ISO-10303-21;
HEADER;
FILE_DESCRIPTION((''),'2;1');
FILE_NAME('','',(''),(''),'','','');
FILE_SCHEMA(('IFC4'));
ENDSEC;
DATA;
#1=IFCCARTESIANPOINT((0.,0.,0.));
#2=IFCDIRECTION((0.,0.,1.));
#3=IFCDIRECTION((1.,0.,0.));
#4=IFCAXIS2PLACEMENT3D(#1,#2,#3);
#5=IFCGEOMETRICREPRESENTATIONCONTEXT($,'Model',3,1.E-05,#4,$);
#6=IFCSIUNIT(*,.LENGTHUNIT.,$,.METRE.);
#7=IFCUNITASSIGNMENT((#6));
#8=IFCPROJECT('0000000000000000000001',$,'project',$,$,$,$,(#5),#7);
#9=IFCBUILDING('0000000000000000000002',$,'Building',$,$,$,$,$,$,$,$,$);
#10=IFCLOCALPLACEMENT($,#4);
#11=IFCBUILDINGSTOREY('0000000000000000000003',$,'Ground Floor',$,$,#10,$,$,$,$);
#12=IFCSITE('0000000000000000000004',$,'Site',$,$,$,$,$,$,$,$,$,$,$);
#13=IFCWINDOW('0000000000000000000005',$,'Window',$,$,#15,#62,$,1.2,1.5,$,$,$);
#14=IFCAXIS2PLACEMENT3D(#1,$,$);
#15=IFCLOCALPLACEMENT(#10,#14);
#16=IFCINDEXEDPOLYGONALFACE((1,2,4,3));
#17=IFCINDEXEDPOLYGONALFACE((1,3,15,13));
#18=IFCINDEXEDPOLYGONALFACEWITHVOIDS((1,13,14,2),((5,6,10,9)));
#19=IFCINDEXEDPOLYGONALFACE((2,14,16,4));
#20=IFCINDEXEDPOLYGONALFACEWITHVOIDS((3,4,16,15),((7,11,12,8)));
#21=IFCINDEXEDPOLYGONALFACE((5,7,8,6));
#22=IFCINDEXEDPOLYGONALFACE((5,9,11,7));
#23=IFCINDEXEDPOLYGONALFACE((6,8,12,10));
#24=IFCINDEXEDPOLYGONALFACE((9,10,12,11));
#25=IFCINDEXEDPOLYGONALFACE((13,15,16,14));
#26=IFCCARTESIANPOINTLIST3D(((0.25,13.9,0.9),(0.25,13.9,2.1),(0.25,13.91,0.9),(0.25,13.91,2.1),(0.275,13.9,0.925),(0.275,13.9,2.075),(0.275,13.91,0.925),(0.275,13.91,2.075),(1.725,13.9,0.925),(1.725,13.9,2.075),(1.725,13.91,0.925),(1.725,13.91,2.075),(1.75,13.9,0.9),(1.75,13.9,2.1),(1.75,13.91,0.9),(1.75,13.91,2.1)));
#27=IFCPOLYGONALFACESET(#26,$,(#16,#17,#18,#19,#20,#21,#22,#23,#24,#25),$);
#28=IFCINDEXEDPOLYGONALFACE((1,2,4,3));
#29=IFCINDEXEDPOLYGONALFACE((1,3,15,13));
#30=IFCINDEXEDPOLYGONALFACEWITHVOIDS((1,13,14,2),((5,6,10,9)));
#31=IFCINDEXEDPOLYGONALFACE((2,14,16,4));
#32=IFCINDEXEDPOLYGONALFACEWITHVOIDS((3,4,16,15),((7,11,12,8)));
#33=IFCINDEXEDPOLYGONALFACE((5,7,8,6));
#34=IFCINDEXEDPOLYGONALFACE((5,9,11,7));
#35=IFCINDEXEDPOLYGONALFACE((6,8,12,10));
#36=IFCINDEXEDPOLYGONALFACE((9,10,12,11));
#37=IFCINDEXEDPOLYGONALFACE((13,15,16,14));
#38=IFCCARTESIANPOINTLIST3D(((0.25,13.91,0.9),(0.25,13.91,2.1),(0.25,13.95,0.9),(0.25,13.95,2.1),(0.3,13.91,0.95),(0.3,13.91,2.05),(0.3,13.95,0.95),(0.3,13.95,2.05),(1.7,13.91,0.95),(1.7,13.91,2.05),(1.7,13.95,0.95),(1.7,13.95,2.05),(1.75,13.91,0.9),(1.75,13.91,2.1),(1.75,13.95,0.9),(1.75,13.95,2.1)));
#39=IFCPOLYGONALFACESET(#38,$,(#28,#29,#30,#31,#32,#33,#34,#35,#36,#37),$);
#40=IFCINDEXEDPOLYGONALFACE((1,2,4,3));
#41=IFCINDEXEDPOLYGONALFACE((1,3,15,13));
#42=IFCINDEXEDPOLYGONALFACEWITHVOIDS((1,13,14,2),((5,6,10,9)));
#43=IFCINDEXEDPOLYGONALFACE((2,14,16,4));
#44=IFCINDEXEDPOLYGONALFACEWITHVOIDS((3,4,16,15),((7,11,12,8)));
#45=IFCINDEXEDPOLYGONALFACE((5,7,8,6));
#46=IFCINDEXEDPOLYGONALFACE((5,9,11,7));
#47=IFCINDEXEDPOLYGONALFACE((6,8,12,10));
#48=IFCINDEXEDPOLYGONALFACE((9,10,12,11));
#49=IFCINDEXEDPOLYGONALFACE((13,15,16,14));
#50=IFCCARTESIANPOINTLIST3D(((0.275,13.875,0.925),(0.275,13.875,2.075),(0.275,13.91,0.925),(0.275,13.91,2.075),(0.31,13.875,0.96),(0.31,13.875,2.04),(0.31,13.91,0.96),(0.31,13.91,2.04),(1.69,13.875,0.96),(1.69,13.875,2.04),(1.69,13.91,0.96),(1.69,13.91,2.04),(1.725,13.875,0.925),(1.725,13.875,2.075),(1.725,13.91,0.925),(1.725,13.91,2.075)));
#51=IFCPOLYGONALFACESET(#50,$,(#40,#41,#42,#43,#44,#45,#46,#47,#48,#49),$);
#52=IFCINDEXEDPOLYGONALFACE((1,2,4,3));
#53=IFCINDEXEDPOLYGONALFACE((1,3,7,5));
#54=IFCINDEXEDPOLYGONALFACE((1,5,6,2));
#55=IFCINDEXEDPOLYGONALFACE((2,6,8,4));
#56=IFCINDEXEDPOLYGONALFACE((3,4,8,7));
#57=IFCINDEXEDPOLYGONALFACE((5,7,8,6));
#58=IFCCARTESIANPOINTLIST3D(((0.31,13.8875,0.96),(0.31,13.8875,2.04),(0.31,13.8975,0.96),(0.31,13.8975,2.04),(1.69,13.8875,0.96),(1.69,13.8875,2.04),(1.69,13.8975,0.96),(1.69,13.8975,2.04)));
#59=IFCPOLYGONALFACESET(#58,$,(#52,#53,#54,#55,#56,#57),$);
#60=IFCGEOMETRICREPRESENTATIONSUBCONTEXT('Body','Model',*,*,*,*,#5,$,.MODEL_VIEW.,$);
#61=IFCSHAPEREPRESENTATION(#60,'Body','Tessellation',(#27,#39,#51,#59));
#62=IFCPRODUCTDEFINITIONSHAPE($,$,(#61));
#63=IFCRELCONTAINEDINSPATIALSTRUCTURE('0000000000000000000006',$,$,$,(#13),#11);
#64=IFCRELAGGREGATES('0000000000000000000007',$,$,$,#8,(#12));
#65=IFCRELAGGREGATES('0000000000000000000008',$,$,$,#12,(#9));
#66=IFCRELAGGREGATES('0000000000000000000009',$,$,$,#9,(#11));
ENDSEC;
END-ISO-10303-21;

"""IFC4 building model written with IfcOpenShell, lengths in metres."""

from ifc_helpers import new_model, si_unit, frame, origin_with_axes, place, context, subcontext, project, spatial, line, indexed_curve, outline, extrude, element, save


model = new_model("IFC4")

# Units and contexts
model_context = context("Model", 3, precision=1e-05, world=origin_with_axes())
body_context = subcontext(model_context, "Body", "Model", "MODEL_VIEW")
ifc_project = project(units=[si_unit("LENGTHUNIT", "METRE")], contexts=[model_context])

# Site, building, storey
site = spatial("IfcSite", under=ifc_project, Name="Site")
building = spatial("IfcBuilding", under=site, Name="Building")
storey_placement = place(None, origin_with_axes())
storey = spatial("IfcBuildingStorey", under=building, at=storey_placement, Name="Ground Floor")

# Window
window_1_placement = place(storey_placement, frame((1.75, 14.0, 0.9), z_axis=(0.0, 0.0, 1.0), x_axis=(-1.0, 0.0, 0.0)))
element("IfcWindow", 1, at=window_1_placement, inside=storey, Name="Window", OverallHeight=1.2, OverallWidth=1.5, context=body_context, shape_type="SweptSolid", body=[
    extrude(outline(indexed_curve([(0.0, 0.0), (1.5, 0.0), (1.5, 1.2), (0.0, 1.2)], segments=[line(1, 2, 3, 4, 1)]), holes=[indexed_curve([(0.025, 0.025), (1.475, 0.025), (1.475, 1.175), (0.025, 1.175)], segments=[line(1, 2, 3, 4, 1)])]), frame((0.0, 0.09, 0.0), z_axis=(0.0, -1.0, 0.0), x_axis=(1.0, 0.0, 0.0)), (0.0, 0.0, -1.0), 0.01),
    extrude(outline(indexed_curve([(0.0, 0.0), (1.5, 0.0), (1.5, 1.2), (0.0, 1.2)], segments=[line(1, 2, 3, 4, 1)]), holes=[indexed_curve([(0.05, 0.05), (1.45, 0.05), (1.45, 1.15), (0.05, 1.15)], segments=[line(1, 2, 3, 4, 1)])]), frame((0.0, 0.05, 0.0), z_axis=(0.0, -1.0, 0.0), x_axis=(1.0, 0.0, 0.0)), (0.0, 0.0, -1.0), 0.04),
    extrude(outline(indexed_curve([(0.0, 0.0), (1.45, 0.0), (1.45, 1.15), (0.0, 1.15)], segments=[line(1, 2, 3, 4, 1)]), holes=[indexed_curve([(0.035, 0.035), (1.415, 0.035), (1.415, 1.115), (0.035, 1.115)], segments=[line(1, 2, 3, 4, 1)])]), frame((0.025, 0.09, 0.025), z_axis=(0.0, -1.0, 0.0), x_axis=(1.0, 0.0, 0.0)), (0.0, 0.0, -1.0), 0.035),
    extrude(outline(indexed_curve([(0.035, 0.035), (1.415, 0.035), (1.415, 1.115), (0.035, 1.115)], segments=[line(1, 2, 3, 4, 1)])), frame((0.025, 0.1025, 0.025), z_axis=(0.0, -1.0, 0.0), x_axis=(1.0, 0.0, 0.0)), (0.0, 0.0, -1.0), 0.01),
])

save(model, "model.ifc")
